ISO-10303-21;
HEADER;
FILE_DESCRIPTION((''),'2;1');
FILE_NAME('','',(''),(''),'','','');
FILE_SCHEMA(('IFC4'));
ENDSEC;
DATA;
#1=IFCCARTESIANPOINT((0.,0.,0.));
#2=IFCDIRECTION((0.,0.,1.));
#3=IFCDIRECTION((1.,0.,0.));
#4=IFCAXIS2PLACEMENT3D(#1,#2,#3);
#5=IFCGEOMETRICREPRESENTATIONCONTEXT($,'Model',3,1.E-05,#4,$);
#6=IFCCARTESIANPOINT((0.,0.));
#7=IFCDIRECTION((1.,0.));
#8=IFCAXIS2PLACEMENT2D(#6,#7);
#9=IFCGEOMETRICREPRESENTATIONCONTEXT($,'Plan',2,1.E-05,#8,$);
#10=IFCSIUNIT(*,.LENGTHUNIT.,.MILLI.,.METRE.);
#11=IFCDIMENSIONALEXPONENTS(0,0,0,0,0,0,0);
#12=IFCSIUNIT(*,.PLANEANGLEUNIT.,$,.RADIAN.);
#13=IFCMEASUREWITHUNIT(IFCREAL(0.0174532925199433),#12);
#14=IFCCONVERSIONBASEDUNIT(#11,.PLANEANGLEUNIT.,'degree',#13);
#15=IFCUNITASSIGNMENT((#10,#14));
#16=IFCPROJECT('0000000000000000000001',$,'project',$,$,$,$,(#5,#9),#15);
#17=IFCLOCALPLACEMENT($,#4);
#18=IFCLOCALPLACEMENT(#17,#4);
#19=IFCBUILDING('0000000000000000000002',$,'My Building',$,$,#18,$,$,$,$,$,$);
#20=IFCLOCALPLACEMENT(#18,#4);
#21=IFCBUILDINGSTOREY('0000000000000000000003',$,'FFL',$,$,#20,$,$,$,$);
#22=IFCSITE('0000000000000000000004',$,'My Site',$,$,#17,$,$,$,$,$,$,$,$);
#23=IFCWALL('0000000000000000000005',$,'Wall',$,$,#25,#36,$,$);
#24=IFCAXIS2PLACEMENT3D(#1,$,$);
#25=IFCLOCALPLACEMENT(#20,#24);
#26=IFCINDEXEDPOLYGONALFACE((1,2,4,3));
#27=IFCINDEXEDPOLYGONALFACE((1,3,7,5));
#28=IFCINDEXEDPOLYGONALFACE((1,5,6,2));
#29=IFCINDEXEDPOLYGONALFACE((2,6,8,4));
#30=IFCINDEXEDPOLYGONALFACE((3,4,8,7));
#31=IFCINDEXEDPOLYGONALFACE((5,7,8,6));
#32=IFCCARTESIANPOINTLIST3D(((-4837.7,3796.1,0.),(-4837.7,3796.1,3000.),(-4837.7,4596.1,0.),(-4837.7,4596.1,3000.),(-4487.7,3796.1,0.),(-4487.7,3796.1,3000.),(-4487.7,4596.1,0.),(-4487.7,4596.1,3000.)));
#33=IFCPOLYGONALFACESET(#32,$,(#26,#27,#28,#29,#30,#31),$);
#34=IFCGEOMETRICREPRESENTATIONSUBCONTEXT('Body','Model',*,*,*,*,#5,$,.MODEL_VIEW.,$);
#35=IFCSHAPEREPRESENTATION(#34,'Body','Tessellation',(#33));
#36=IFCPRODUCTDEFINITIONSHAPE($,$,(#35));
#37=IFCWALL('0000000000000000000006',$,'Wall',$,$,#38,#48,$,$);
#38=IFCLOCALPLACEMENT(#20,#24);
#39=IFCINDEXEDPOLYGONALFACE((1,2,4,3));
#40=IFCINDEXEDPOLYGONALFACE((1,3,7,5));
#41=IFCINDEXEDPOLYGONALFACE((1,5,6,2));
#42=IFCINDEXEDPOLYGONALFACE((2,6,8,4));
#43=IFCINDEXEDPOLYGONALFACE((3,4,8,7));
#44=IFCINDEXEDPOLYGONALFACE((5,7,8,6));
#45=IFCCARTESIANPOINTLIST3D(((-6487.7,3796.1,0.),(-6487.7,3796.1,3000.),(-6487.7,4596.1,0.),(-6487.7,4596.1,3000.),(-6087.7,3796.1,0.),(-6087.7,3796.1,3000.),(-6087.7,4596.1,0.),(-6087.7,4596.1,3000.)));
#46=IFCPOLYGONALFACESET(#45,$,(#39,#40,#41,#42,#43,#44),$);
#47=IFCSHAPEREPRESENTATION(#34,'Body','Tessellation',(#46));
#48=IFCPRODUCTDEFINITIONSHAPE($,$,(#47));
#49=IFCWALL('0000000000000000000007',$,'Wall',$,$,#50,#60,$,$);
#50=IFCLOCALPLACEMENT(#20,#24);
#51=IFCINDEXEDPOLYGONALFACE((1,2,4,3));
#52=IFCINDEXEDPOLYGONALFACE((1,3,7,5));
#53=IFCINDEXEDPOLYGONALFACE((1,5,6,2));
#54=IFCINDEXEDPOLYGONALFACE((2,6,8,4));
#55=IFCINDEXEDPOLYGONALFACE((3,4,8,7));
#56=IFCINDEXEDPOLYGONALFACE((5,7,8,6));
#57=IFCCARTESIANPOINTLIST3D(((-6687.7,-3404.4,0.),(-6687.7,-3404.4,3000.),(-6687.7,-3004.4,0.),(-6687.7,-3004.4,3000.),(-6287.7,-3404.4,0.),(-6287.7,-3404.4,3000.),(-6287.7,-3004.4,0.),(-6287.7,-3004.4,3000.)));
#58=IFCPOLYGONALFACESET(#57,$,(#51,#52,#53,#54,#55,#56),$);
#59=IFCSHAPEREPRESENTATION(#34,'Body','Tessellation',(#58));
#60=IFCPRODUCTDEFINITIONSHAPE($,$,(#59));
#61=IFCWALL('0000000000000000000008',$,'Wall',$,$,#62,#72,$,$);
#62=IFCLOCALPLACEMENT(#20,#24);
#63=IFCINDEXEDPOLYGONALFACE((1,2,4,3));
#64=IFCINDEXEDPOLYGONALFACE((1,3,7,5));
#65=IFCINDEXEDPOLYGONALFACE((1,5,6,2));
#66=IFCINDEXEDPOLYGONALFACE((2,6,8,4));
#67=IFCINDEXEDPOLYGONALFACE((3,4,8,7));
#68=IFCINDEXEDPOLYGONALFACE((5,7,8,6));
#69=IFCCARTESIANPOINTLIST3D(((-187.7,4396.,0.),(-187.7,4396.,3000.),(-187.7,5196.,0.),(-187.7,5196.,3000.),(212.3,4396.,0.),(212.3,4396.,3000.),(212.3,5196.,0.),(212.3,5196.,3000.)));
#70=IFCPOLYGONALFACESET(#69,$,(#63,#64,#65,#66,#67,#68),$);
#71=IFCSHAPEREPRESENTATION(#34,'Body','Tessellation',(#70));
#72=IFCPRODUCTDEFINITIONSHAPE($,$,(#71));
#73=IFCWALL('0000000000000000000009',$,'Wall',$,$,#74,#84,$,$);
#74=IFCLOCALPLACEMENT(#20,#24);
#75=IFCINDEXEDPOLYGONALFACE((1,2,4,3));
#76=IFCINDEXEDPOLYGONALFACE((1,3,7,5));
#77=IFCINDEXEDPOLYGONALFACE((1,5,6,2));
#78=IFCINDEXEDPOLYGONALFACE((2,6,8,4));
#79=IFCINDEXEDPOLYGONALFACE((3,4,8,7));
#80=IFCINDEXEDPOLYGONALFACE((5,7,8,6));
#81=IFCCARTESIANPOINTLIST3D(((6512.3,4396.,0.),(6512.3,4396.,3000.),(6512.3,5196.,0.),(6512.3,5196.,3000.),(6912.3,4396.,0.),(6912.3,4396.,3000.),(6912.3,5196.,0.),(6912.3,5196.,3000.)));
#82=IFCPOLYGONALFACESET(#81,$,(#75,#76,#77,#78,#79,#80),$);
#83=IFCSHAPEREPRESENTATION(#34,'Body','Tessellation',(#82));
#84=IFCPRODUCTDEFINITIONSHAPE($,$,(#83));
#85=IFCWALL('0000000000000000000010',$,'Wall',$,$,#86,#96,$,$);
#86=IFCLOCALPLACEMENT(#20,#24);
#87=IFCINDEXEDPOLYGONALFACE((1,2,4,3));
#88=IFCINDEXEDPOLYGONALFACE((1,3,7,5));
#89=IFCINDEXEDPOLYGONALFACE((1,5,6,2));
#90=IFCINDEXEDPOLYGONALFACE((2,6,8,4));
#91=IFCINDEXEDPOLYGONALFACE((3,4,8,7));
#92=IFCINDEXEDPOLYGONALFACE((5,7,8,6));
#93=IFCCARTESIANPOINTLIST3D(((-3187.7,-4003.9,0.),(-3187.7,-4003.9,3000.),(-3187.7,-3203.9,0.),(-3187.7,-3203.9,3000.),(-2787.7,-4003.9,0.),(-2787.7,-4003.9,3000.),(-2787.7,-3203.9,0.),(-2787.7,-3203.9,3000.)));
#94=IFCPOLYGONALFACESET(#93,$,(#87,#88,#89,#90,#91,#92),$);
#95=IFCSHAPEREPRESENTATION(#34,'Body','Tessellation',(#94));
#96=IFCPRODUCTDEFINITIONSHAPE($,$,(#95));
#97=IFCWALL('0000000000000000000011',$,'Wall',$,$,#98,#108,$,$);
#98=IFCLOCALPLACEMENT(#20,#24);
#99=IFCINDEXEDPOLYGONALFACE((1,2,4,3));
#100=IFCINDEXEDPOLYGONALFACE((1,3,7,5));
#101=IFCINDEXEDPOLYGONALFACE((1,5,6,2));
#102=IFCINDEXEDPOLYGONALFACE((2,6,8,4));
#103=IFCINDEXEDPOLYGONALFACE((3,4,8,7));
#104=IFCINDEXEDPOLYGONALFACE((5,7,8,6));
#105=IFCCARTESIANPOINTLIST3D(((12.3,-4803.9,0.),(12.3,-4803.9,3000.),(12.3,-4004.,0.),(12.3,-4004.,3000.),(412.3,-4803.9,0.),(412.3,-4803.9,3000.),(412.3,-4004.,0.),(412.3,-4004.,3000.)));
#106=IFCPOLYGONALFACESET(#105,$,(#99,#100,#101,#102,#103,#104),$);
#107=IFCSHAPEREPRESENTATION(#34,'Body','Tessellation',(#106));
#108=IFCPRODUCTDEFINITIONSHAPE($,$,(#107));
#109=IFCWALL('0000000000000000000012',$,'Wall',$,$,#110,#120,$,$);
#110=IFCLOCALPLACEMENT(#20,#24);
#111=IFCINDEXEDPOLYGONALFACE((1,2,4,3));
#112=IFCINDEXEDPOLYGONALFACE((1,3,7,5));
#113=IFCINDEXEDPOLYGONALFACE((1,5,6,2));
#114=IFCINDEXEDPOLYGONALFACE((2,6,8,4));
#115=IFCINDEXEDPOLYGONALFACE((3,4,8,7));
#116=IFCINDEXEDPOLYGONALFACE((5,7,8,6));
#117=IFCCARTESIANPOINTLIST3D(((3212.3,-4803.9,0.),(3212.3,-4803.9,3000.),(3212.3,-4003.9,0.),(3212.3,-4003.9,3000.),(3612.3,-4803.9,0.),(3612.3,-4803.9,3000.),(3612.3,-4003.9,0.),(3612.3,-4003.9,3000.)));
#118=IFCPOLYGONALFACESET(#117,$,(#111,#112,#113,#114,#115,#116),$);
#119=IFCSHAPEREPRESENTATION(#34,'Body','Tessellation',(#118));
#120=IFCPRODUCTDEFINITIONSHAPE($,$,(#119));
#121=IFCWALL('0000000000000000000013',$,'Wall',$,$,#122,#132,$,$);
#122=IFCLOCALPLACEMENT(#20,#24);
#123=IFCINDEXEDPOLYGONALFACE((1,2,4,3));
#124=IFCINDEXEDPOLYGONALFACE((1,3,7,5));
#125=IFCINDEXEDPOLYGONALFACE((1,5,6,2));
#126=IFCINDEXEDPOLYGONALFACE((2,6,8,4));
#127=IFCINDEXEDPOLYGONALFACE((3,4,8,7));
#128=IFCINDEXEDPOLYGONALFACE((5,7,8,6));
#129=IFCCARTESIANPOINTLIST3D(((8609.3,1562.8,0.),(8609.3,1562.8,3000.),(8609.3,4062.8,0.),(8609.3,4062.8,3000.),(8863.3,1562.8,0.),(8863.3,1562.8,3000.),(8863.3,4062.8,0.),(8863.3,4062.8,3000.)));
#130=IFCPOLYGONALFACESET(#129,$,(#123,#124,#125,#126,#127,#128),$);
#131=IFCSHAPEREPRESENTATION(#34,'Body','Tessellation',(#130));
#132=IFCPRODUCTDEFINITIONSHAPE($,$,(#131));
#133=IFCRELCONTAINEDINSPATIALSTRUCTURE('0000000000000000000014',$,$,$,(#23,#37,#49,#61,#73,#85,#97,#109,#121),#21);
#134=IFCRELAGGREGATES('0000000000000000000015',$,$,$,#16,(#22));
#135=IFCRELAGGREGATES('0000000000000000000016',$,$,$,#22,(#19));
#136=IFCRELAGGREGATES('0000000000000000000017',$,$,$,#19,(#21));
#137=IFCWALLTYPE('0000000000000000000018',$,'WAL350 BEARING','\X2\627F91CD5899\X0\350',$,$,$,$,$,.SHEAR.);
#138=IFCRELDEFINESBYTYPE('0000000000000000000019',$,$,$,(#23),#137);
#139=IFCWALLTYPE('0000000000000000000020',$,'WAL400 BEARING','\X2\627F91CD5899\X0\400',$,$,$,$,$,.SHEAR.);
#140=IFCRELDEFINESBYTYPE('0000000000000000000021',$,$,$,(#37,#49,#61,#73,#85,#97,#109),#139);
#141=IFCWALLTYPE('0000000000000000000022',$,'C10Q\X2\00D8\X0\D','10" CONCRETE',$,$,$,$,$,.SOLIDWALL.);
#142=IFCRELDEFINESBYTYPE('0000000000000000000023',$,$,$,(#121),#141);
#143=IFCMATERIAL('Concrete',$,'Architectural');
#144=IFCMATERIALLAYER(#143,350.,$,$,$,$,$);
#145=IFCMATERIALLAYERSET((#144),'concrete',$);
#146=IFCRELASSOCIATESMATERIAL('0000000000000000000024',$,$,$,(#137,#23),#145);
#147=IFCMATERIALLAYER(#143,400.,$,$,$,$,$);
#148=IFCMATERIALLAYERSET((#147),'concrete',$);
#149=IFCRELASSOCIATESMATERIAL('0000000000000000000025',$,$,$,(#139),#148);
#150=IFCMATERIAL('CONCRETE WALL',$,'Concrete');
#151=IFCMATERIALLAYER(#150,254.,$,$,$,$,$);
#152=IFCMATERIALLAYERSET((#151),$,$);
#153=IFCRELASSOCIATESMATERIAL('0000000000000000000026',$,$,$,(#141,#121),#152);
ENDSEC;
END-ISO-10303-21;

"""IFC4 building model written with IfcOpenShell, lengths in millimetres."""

from ifc_helpers import new_model, entity, si_unit, converted_unit, frame, origin_with_axes, origin_2d_with_axis, place, context, subcontext, project, spatial, line, indexed_curve, outline, extrude, material, layer, layer_set, layer_usage, type_object, element, save


model = new_model("IFC4")

# Units and contexts
model_context = context("Model", 3, precision=1e-05, world=origin_with_axes())
plan_context = context("Plan", 2, precision=1e-05, world=origin_2d_with_axis())
body_context = subcontext(model_context, "Body", "Model", "MODEL_VIEW")
ifc_project = project(units=[si_unit("LENGTHUNIT", "METRE", prefix="MILLI"), converted_unit("PLANEANGLEUNIT", "degree", entity("IfcReal", 0.0174532925199433), si_unit("PLANEANGLEUNIT", "RADIAN"), dimensions=[0, 0, 0, 0, 0, 0, 0])], contexts=[model_context, plan_context])

# Site, building, storey
site_placement = place(None, origin_with_axes())
site = spatial("IfcSite", under=ifc_project, at=site_placement, Name="My Site")
building_placement = place(site_placement, origin_with_axes())
building = spatial("IfcBuilding", under=site, at=building_placement, Name="My Building")
storey_placement = place(building_placement, origin_with_axes())
storey = spatial("IfcBuildingStorey", under=building, at=storey_placement, Name="FFL")

# Walls
ifc_material_1 = material(Name="Concrete", Category="Architectural")
ifc_layer_1 = layer(ifc_material_1, 350.0)
ifc_layer_set_1 = layer_set([ifc_layer_1], Name="concrete")
ifc_layer_usage_1 = layer_usage(ifc_layer_set_1, "AXIS2", "POSITIVE", 0.0)
wall_type_1 = type_object("IfcWallType", Name="WAL350 BEARING", Description="承重墙350", PredefinedType="SHEAR", material=ifc_layer_set_1)
wall_1_placement = place(storey_placement, frame((-4487.7, 3796.1, 0.0), z_axis=(0.0, 0.0, 1.0), x_axis=(0.0, 1.0, 0.0)))
element("IfcWall", 1, at=wall_1_placement, inside=storey, type_object=wall_type_1, material=ifc_layer_usage_1, Name="Wall", context=body_context, shape_type="SweptSolid", body=[
    extrude(outline(indexed_curve([(0.0, 0.0), (0.0, 350.0), (800.0, 350.0), (800.0, 0.0)], segments=[line(1, 2, 3, 4, 1)])), origin_with_axes(), (0.0, 0.0, 1.0), 3000.0),
])
ifc_layer_2 = layer(ifc_material_1, 400.0)
ifc_layer_set_2 = layer_set([ifc_layer_2], Name="concrete")
wall_type_2 = type_object("IfcWallType", Name="WAL400 BEARING", Description="承重墙400", PredefinedType="SHEAR", material=ifc_layer_set_2)
wall_2_placement = place(storey_placement, frame((-6087.7, 3796.1, 0.0), z_axis=(0.0, 0.0, 1.0), x_axis=(0.0, 1.0, 0.0)))
element("IfcWall", 2, at=wall_2_placement, inside=storey, type_object=wall_type_2, Name="Wall", context=body_context, shape_type="SweptSolid", body=[
    extrude(outline(indexed_curve([(0.0, 0.0), (0.0, 400.0), (800.0, 400.0), (800.0, 0.0), (0.0, 0.0)])), origin_with_axes(), (0.0, 0.0, 1.0), 3000.0),
])
wall_3_placement = place(storey_placement, frame((-6687.7, -3004.4, 0.0), z_axis=(0.0, 0.0, 1.0), x_axis=(0.0, -1.0, 0.0)))
element("IfcWall", 3, at=wall_3_placement, inside=storey, type_object=wall_type_2, Name="Wall", context=body_context, shape_type="SweptSolid", body=[
    extrude(outline(indexed_curve([(400.0, 0.0), (400.0, 400.0), (0.0, 400.0), (0.0, 0.0), (400.0, 0.0)])), origin_with_axes(), (0.0, 0.0, 1.0), 3000.0),
])
wall_4_placement = place(storey_placement, frame((212.3, 4396.0, 0.0), z_axis=(0.0, 0.0, 1.0), x_axis=(0.0, 1.0, 0.0)))
element("IfcWall", 4, at=wall_4_placement, inside=storey, type_object=wall_type_2, Name="Wall", context=body_context, shape_type="SweptSolid", body=[
    extrude(outline(indexed_curve([(799.9, 0.0), (799.9, 400.0), (0.0, 400.0), (0.0, 0.0), (799.9, 0.0)])), origin_with_axes(), (0.0, 0.0, 1.0), 3000.0),
])
for number, where, z_axis, x_axis, name in (
    (5, (6912.3, 4396.0, 0.0), (0.0, 0.0, 1.0), (0.000001, 1.0, 0.0), "Wall"),
    (6, (-3187.7, -3203.9, 0.0), (0.0, 0.0, 1.0), (0.000014, -1.0, 0.0), "Wall"),
):
    element("IfcWall", number, at=place(storey_placement, frame(where, z_axis=z_axis, x_axis=x_axis)), inside=storey, type_object=wall_type_2, Name=name, context=body_context, shape_type="SweptSolid", body=[
        extrude(outline(indexed_curve([(800.0, 0.0), (800.0, 400.0), (0.0, 400.0), (0.0, 0.0), (800.0, 0.0)])), origin_with_axes(), (0.0, 0.0, 1.0), 3000.0),
    ])
wall_5_placement = place(storey_placement, frame((12.3, -4004.0, 0.0), z_axis=(0.0, 0.0, 1.0), x_axis=(0.0, -1.0, 0.0)))
element("IfcWall", 7, at=wall_5_placement, inside=storey, type_object=wall_type_2, Name="Wall", context=body_context, shape_type="SweptSolid", body=[
    extrude(outline(indexed_curve([(0.0, 0.0), (0.0, 400.0), (800.0, 400.0), (800.0, 0.0), (0.0, 0.0)])), origin_with_axes(), (0.0, 0.0, 1.0), 3000.0),
])
wall_6_placement = place(storey_placement, frame((3612.3, -4803.9, 0.0), z_axis=(0.0, 0.0, 1.0), x_axis=(0.0, 1.0, 0.0)))
element("IfcWall", 8, at=wall_6_placement, inside=storey, type_object=wall_type_2, Name="Wall", context=body_context, shape_type="SweptSolid", body=[
    extrude(outline(indexed_curve([(800.0, 0.0), (800.0, 400.0), (0.0, 400.0), (0.0, 0.0), (800.0, 0.0)])), origin_with_axes(), (0.0, 0.0, 1.0), 3000.0),
])
ifc_material_2 = material(Name="CONCRETE WALL", Category="Concrete")
ifc_layer_3 = layer(ifc_material_2, 254.0)
ifc_layer_set_3 = layer_set([ifc_layer_3])
ifc_layer_usage_2 = layer_usage(ifc_layer_set_3, "AXIS2", "POSITIVE", 0.0)
wall_type_3 = type_object("IfcWallType", Name="C10QØD", Description="10\" CONCRETE", PredefinedType="SOLIDWALL", material=ifc_layer_set_3)
wall_7_placement = place(storey_placement, frame((8863.3, 1562.8, 0.0), z_axis=(0.0, 0.0, 1.0), x_axis=(0.0, 1.0, 0.0)))
element("IfcWall", 9, at=wall_7_placement, inside=storey, type_object=wall_type_3, material=ifc_layer_usage_2, Name="Wall", context=body_context, shape_type="SweptSolid", body=[
    extrude(outline(indexed_curve([(0.0, 0.0), (0.0, 254.0), (2500.0, 254.0), (2500.0, 0.0)], segments=[line(1, 2, 3, 4, 1)])), origin_with_axes(), (0.0, 0.0, 1.0), 3000.0),
])

save(model, "model.ifc")
